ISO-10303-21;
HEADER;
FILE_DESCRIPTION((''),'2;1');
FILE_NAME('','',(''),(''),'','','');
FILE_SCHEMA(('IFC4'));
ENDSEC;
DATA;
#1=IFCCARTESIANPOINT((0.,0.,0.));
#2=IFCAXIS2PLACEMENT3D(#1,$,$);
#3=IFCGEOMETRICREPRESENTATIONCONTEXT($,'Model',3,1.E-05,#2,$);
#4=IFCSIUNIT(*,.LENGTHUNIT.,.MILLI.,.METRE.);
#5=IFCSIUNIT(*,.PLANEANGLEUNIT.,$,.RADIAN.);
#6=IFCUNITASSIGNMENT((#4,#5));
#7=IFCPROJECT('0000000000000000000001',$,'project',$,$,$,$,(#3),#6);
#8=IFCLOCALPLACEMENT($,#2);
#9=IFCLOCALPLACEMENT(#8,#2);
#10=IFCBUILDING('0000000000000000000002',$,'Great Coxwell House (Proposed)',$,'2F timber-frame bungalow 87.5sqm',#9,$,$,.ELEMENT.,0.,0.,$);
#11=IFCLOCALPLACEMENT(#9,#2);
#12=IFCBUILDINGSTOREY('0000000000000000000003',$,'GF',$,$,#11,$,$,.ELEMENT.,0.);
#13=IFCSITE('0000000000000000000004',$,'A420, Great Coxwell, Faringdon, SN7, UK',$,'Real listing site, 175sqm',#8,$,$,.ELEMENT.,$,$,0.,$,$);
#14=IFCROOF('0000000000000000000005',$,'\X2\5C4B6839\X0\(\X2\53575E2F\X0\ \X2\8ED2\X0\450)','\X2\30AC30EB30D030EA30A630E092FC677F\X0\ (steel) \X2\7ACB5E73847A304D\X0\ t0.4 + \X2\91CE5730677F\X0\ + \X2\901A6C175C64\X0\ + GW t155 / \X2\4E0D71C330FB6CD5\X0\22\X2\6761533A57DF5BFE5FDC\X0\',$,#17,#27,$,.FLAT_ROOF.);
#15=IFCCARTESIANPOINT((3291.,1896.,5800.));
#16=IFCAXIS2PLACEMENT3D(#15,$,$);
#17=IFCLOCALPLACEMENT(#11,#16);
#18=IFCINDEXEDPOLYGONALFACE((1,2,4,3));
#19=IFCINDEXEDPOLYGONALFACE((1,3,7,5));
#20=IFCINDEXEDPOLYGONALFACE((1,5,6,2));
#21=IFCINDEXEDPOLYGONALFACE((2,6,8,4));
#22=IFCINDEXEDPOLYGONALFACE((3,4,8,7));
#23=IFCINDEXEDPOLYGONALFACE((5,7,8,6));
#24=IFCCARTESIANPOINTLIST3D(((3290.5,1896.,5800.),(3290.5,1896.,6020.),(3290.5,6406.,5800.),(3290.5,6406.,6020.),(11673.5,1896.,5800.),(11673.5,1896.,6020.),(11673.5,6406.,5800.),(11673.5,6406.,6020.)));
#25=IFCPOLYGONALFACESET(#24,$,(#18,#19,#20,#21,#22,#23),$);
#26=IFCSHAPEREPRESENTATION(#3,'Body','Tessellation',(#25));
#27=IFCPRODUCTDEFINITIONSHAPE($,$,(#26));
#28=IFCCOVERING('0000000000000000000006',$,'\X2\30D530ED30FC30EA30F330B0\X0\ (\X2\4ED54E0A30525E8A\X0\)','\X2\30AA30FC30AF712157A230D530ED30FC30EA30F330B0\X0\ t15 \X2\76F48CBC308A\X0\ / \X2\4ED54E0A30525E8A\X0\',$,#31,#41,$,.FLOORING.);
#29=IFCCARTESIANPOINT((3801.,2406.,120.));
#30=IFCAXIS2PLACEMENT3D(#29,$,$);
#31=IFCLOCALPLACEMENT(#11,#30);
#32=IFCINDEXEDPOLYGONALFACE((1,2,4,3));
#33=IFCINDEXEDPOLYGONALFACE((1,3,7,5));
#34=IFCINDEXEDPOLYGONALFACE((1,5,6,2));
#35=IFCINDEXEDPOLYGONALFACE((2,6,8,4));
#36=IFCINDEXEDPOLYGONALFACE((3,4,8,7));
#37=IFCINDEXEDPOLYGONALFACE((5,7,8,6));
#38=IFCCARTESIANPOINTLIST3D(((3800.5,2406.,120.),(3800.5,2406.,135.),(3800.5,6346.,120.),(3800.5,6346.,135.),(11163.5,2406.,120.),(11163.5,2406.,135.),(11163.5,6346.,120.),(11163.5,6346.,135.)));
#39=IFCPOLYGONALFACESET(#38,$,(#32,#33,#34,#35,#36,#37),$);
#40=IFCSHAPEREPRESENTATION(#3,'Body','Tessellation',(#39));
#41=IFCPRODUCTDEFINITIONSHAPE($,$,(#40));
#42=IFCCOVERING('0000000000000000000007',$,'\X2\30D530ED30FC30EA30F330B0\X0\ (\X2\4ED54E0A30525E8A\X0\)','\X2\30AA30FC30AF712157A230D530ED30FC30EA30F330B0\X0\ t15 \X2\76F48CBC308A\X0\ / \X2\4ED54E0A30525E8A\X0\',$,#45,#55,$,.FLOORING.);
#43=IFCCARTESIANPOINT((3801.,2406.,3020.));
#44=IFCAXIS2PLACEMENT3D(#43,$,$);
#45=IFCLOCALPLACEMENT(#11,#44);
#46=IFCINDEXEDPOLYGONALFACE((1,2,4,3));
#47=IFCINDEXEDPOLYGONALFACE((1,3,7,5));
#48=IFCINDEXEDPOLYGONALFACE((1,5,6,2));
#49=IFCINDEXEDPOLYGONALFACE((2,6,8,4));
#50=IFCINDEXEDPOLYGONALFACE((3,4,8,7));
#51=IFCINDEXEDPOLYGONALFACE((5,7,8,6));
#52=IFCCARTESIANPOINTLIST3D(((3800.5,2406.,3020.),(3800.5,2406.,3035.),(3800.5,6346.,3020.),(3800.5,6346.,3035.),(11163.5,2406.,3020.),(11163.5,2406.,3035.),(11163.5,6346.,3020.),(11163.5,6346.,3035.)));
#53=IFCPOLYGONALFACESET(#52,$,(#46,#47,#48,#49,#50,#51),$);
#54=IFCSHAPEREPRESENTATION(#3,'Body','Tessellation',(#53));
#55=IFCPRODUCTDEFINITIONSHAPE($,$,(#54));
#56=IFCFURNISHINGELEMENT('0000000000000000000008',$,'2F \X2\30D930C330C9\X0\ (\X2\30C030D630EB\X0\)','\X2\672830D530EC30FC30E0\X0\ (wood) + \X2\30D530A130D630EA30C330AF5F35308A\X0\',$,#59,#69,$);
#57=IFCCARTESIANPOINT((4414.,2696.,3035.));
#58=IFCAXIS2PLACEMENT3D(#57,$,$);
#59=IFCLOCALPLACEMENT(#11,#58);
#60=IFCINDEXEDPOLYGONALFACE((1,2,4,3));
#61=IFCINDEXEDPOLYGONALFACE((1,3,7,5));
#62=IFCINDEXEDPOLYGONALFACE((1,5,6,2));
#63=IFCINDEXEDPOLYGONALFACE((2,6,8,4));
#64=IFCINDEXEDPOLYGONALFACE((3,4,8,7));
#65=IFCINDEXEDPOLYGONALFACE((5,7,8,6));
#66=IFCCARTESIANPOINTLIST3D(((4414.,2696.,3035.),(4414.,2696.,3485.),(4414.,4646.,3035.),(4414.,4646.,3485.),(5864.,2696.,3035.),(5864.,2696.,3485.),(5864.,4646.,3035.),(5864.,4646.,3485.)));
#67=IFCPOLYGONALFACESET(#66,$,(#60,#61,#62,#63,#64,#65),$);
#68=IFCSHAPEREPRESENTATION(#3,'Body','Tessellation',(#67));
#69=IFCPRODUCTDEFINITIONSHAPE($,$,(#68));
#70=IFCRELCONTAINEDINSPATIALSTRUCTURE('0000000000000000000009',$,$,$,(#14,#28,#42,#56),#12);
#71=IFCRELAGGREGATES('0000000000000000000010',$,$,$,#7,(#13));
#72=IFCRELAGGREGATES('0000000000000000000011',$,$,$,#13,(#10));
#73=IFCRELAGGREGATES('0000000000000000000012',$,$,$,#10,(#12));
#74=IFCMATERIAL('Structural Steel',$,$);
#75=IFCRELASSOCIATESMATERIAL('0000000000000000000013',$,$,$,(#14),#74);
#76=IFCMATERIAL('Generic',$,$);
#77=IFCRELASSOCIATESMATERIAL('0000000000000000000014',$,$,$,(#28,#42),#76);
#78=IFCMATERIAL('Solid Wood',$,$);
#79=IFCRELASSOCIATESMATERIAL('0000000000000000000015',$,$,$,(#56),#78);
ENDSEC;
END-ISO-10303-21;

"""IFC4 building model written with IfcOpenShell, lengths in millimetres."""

from ifc_helpers import new_model, si_unit, frame, frame_2d, origin, place, context, project, spatial, rectangle, extrude, material, element, save


model = new_model("IFC4")

# Units and contexts
model_context = context("Model", 3, precision=1e-05, world=origin())
ifc_project = project(units=[si_unit("LENGTHUNIT", "METRE", prefix="MILLI"), si_unit("PLANEANGLEUNIT", "RADIAN")], contexts=[model_context])

# Site, building, storey
site_placement = place(None, origin())
site = spatial("IfcSite", under=ifc_project, at=site_placement, Name="A420, Great Coxwell, Faringdon, SN7, UK", ObjectType="Real listing site, 175sqm", CompositionType="ELEMENT", RefElevation=0.0)
building_placement = place(site_placement, origin())
building = spatial("IfcBuilding", under=site, at=building_placement, Name="Great Coxwell House (Proposed)", ObjectType="2F timber-frame bungalow 87.5sqm", CompositionType="ELEMENT", ElevationOfRefHeight=0.0, ElevationOfTerrain=0.0)
storey_placement = place(building_placement, origin())
storey = spatial("IfcBuildingStorey", under=building, at=storey_placement, Name="GF", CompositionType="ELEMENT", Elevation=0.0)

# Shared definitions
ifc_material_1 = material(Name="Solid Wood")

# Roof
ifc_material_2 = material(Name="Structural Steel")
for number, where, name in (
    (1, (3291.0, 1896.0, 5800.0), "屋根(南帯 軒450)"),
):
    element("IfcRoof", number, at=place(storey_placement, frame(where)), inside=storey, material=ifc_material_2, Name=name, Description="ガルバリウム鋼板 (steel) 立平葺き t0.4 + 野地板 + 通気層 + GW t155 / 不燃・法22条区域対応", PredefinedType="FLAT_ROOF", context=model_context, shape_type="SweptSolid", body=[
        extrude(rectangle(XDim=8383.0, YDim=4510.0, at=frame_2d((4191.0, 2255.0))), frame((3291.0, 1896.0, 5800.0)), (0.0, 0.0, 1.0), 220.0),
    ])

# Coverings
ifc_material_3 = material(Name="Generic")
covering_1_placement = place(storey_placement, frame((3801.0, 2406.0, 120.0)))
element("IfcCovering", 2, at=covering_1_placement, inside=storey, material=ifc_material_3, Name="フローリング (仕上げ床)", Description="オーク無垢フローリング t15 直貼り / 仕上げ床", PredefinedType="FLOORING", context=model_context, shape_type="SweptSolid", body=[
    extrude(rectangle(XDim=7363.0, YDim=3940.0, at=frame_2d((3681.0, 1970.0))), frame((3801.0, 2406.0, 120.0)), (0.0, 0.0, 1.0), 15.0),
])
covering_2_placement = place(storey_placement, frame((3801.0, 2406.0, 3020.0)))
element("IfcCovering", 3, at=covering_2_placement, inside=storey, material=ifc_material_3, Name="フローリング (仕上げ床)", Description="オーク無垢フローリング t15 直貼り / 仕上げ床", PredefinedType="FLOORING", context=model_context, shape_type="SweptSolid", body=[
    extrude(rectangle(XDim=7363.0, YDim=3940.0, at=frame_2d((3681.0, 1970.0))), frame((3801.0, 2406.0, 3020.0)), (0.0, 0.0, 1.0), 15.0),
])

# Furnishing element
furnishing_placement = place(storey_placement, frame((4414.0, 2696.0, 3035.0)))
element("IfcFurnishingElement", 4, at=furnishing_placement, inside=storey, material=ifc_material_1, Name="2F ベッド (ダブル)", Description="木フレーム (wood) + ファブリック張り", context=model_context, shape_type="SweptSolid", body=[
    extrude(rectangle(XDim=1450.0, YDim=1950.0, at=frame_2d((725.0, 975.0))), frame((4414.0, 2696.0, 3035.0)), (0.0, 0.0, 1.0), 450.0),
])

save(model, "model.ifc")
